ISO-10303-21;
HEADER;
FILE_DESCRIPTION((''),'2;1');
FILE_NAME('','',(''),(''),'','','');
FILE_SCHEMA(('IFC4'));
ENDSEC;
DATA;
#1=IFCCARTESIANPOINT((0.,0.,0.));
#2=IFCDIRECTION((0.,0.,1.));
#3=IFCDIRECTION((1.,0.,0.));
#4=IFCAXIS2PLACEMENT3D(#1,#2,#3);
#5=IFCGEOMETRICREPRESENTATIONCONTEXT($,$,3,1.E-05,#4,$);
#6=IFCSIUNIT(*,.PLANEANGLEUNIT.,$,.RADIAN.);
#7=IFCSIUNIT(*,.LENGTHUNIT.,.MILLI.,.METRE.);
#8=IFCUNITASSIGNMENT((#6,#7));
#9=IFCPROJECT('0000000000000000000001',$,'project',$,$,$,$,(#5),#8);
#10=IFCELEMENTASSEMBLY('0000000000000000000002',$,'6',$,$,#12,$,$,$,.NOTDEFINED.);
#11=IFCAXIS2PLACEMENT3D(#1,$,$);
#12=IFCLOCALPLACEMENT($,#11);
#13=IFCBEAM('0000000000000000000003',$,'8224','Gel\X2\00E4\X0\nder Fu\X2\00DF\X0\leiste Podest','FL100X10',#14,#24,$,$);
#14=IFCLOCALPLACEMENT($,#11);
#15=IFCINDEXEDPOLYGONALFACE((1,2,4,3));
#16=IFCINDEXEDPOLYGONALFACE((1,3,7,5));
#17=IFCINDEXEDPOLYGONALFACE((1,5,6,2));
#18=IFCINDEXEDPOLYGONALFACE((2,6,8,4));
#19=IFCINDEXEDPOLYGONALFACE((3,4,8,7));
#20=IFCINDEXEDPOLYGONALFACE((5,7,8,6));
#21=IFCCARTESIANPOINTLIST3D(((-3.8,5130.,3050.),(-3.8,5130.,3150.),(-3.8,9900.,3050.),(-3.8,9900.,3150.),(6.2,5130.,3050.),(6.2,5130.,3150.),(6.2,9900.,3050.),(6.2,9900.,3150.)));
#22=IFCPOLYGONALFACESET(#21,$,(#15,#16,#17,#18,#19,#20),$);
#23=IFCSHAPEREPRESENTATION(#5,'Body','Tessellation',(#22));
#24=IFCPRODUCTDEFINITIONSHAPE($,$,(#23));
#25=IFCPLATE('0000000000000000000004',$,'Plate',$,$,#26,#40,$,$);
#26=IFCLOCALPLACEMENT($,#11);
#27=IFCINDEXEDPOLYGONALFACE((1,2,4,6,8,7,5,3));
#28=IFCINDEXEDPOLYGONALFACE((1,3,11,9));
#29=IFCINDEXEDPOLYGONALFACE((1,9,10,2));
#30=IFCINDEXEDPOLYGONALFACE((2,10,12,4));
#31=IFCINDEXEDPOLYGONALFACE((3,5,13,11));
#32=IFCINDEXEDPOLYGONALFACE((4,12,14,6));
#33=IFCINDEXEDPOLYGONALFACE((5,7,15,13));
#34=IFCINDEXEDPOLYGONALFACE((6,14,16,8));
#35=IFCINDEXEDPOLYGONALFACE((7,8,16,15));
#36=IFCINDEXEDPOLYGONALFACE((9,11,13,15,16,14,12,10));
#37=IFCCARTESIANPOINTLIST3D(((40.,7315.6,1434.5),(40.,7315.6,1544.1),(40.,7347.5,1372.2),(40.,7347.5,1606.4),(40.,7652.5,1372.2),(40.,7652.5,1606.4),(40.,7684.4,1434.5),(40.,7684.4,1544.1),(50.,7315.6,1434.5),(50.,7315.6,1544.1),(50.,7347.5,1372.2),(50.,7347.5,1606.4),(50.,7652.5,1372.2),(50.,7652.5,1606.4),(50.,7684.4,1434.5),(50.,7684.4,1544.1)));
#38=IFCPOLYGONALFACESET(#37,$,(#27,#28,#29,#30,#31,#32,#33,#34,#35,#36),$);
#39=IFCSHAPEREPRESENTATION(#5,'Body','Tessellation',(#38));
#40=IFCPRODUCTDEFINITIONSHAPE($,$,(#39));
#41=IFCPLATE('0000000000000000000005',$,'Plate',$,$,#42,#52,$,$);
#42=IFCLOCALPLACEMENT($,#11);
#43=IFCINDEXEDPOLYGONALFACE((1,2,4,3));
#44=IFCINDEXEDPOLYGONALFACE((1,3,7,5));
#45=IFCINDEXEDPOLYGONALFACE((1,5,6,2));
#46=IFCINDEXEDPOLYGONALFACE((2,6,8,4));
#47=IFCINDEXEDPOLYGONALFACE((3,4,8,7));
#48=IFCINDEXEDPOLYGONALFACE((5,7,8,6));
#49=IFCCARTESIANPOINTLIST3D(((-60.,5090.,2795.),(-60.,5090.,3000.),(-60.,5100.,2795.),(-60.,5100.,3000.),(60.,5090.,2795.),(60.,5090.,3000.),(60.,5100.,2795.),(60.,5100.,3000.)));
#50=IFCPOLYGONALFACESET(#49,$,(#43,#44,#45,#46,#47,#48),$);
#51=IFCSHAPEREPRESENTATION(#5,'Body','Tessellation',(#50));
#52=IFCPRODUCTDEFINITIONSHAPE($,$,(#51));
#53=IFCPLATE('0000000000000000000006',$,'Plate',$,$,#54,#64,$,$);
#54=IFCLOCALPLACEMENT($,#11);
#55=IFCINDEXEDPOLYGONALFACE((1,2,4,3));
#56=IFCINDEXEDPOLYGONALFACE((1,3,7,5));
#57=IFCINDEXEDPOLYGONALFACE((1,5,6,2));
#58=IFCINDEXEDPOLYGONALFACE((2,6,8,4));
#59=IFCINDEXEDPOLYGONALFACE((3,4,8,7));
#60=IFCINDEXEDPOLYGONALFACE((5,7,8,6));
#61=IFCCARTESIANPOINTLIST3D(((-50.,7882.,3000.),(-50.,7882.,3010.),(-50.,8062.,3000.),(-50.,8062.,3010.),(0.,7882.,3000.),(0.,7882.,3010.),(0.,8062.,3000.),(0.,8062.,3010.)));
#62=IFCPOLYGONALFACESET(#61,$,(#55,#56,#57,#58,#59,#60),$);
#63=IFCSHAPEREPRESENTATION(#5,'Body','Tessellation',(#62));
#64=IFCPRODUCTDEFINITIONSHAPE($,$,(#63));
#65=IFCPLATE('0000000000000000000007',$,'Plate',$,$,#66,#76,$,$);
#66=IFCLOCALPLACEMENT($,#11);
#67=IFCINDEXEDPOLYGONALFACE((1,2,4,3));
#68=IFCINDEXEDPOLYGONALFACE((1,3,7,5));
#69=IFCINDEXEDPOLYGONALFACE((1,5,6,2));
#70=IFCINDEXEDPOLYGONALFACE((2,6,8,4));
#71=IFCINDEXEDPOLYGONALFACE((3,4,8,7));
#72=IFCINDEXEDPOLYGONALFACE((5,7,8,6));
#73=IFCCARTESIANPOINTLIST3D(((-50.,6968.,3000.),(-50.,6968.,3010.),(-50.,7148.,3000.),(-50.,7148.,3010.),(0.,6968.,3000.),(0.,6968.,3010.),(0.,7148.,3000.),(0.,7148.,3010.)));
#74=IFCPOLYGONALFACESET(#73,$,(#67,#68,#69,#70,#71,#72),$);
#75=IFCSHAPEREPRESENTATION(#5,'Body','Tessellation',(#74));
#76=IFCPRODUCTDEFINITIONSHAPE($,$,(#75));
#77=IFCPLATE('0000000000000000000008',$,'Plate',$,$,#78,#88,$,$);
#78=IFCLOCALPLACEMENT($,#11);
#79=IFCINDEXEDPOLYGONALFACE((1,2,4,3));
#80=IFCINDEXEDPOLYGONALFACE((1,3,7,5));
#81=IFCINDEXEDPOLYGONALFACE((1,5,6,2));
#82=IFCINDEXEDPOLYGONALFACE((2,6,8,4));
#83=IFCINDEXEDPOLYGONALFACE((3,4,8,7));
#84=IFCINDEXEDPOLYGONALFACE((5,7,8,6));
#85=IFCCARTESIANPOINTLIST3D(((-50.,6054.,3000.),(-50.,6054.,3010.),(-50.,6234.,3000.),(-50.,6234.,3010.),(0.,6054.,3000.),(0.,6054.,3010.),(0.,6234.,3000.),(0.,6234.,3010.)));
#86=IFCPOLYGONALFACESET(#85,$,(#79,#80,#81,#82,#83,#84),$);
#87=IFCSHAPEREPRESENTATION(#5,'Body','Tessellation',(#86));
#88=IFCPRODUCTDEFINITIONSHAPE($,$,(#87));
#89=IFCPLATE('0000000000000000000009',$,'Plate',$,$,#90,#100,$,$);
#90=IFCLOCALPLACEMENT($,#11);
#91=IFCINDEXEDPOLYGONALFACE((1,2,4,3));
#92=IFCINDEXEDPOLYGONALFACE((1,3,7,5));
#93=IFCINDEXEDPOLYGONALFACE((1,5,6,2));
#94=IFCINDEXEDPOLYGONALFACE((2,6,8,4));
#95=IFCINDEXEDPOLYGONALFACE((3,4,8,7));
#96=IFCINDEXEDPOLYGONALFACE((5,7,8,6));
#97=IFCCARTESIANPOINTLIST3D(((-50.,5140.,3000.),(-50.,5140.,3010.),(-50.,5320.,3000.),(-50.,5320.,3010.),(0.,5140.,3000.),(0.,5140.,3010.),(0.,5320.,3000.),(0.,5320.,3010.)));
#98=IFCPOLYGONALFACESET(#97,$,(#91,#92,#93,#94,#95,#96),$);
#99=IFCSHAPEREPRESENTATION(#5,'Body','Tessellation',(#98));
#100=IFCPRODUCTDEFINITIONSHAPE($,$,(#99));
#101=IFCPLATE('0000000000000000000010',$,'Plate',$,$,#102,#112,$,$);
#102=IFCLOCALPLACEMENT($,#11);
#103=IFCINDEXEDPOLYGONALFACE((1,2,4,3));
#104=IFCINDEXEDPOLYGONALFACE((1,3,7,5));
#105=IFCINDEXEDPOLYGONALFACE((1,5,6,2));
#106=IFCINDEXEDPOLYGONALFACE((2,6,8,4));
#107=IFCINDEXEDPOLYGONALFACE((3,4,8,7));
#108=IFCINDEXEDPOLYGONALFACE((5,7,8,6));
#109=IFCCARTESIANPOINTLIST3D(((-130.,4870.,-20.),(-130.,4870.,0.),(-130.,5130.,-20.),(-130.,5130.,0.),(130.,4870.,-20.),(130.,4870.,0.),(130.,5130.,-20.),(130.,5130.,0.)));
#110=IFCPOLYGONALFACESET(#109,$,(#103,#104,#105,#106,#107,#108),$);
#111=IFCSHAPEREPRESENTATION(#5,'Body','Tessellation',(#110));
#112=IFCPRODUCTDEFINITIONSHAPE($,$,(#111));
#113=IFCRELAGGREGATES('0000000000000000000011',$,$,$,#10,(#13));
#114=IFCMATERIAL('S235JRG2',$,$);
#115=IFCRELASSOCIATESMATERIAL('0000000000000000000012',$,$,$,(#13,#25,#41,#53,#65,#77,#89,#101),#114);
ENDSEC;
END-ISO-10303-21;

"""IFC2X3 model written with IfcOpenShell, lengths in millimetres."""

from ifc_helpers import new_model, si_unit, frame, origin_with_axes, place, context, project, polyline, outline, extrude, material, element, aggregate, save


model = new_model("IFC2X3")

# Units and contexts
context_of_model = context(None, 3, precision=1e-05, world=origin_with_axes())
ifc_project = project(units=[si_unit("PLANEANGLEUNIT", "RADIAN"), si_unit("LENGTHUNIT", "METRE", prefix="MILLI")], contexts=[context_of_model])

# Element assembly, beam
assembly_1_placement = place(None, frame((1.2, 5130.0, 6100.0), z_axis=(0.0, 0.0, 1.0), x_axis=(0.0, 1.0, 0.0)))
assembly_1 = element("IfcElementAssembly", 1, at=assembly_1_placement, Name="6", PredefinedType="NOTDEFINED")
ifc_material = material(Name="S235JRG2")
placement_1 = place(None, frame((1.2, 5130.0, 3100.0), z_axis=(0.0, 0.0, 1.0), x_axis=(0.0, 1.0, 0.0)))
beam_1_placement = place(placement_1, origin_with_axes())
beam_1 = element("IfcBeam", 2, at=beam_1_placement, material=ifc_material, Name="8224", Description="Geländer Fußleiste Podest", ObjectType="FL100X10", context=context_of_model, shape_type="SweptSolid", body=[
    extrude(outline(polyline([(5.0, -50.0), (5.0, 50.0), (-5.0, 50.0), (-5.0, -50.0), (5.0, -50.0), (5.0, -50.0)])), frame((0.0, 0.0, 0.0), z_axis=(1.0, 0.0, 0.0), x_axis=(0.0, 1.0, 0.0)), (0.0, 0.0, 1.0), 4770.0),
])
aggregate(assembly_1, [beam_1])

# Plates
placement_2 = place(None, frame((40.0, 7684.4, 1434.5), z_axis=(0.0, -1.0, 0.0), x_axis=(1.0, 0.0, 0.0)))
plate_1_placement = place(placement_2, origin_with_axes())
element("IfcPlate", 3, at=plate_1_placement, material=ifc_material, Name="Plate", context=context_of_model, shape_type="SweptSolid", body=[
    extrude(outline(polyline([(0.0, 0.0), (109.5, 0.0), (171.9, 31.8), (171.9, 336.9), (109.5, 368.7), (0.0, 368.7), (-62.4, 336.9), (-62.4, 31.8), (0.0, 0.0)])), frame((0.0, 0.0, 0.0), z_axis=(1.0, 0.0, 0.0), x_axis=(0.0, 1.0, 0.0)), (0.0, 0.0, 1.0), 10.0),
])
placement_3 = place(None, origin_with_axes())
plate_2_placement = place(placement_3, frame((60.0, 5100.0, 3000.0), z_axis=(0.0, 0.0, -1.0), x_axis=(0.0, -1.0, 0.0)))
element("IfcPlate", 4, at=plate_2_placement, material=ifc_material, Name="Plate", context=context_of_model, shape_type="SweptSolid", body=[
    extrude(outline(polyline([(0.0, 0.0), (120.0, 0.0), (120.0, 205.0), (0.0, 205.0), (0.0, 0.0)])), frame((0.0, 0.0, 0.0), z_axis=(1.0, 0.0, 0.0), x_axis=(0.0, 1.0, 0.0)), (0.0, 0.0, 1.0), 10.0),
])
placement_4 = place(None, origin_with_axes())
plate_3_placement = place(placement_4, frame((0.0, 8062.0, 3010.0), z_axis=(-1.0, 0.0, 0.0), x_axis=(0.0, 0.0, -1.0)))
element("IfcPlate", 5, at=plate_3_placement, material=ifc_material, Name="Plate", context=context_of_model, shape_type="SweptSolid", body=[
    extrude(outline(polyline([(0.0, 0.0), (180.0, 0.0), (180.0, 50.0), (0.0, 50.0), (0.0, 0.0)])), frame((0.0, 0.0, 0.0), z_axis=(1.0, 0.0, 0.0), x_axis=(0.0, 1.0, 0.0)), (0.0, 0.0, 1.0), 10.0),
])
placement_5 = place(None, origin_with_axes())
plate_4_placement = place(placement_5, frame((0.0, 7148.0, 3010.0), z_axis=(-1.0, 0.0, 0.0), x_axis=(0.0, 0.0, -1.0)))
element("IfcPlate", 6, at=plate_4_placement, material=ifc_material, Name="Plate", context=context_of_model, shape_type="SweptSolid", body=[
    extrude(outline(polyline([(0.0, 0.0), (180.0, 0.0), (180.0, 50.0), (0.0, 50.0), (0.0, 0.0)])), frame((0.0, 0.0, 0.0), z_axis=(1.0, 0.0, 0.0), x_axis=(0.0, 1.0, 0.0)), (0.0, 0.0, 1.0), 10.0),
])
placement_6 = place(None, origin_with_axes())
plate_5_placement = place(placement_6, frame((0.0, 6234.0, 3010.0), z_axis=(-1.0, 0.0, 0.0), x_axis=(0.0, 0.0, -1.0)))
element("IfcPlate", 7, at=plate_5_placement, material=ifc_material, Name="Plate", context=context_of_model, shape_type="SweptSolid", body=[
    extrude(outline(polyline([(0.0, 0.0), (180.0, 0.0), (180.0, 50.0), (0.0, 50.0), (0.0, 0.0)])), frame((0.0, 0.0, 0.0), z_axis=(1.0, 0.0, 0.0), x_axis=(0.0, 1.0, 0.0)), (0.0, 0.0, 1.0), 10.0),
])
placement_7 = place(None, origin_with_axes())
plate_6_placement = place(placement_7, frame((0.0, 5320.0, 3010.0), z_axis=(-1.0, 0.0, 0.0), x_axis=(0.0, 0.0, -1.0)))
element("IfcPlate", 8, at=plate_6_placement, material=ifc_material, Name="Plate", context=context_of_model, shape_type="SweptSolid", body=[
    extrude(outline(polyline([(0.0, 0.0), (180.0, 0.0), (180.0, 50.0), (0.0, 50.0), (0.0, 0.0)])), frame((0.0, 0.0, 0.0), z_axis=(1.0, 0.0, 0.0), x_axis=(0.0, 1.0, 0.0)), (0.0, 0.0, 1.0), 10.0),
])
placement_8 = place(None, origin_with_axes())
plate_7_placement = place(placement_8, frame((130.0, 5130.0, 0.0), z_axis=(-1.0, 0.0, 0.0), x_axis=(0.0, 0.0, -1.0)))
element("IfcPlate", 9, at=plate_7_placement, material=ifc_material, Name="Plate", context=context_of_model, shape_type="SweptSolid", body=[
    extrude(outline(polyline([(0.0, 0.0), (260.0, 0.0), (260.0, 260.0), (0.0, 260.0), (0.0, 0.0)])), frame((0.0, 0.0, 0.0), z_axis=(1.0, 0.0, 0.0), x_axis=(0.0, 1.0, 0.0)), (0.0, 0.0, 1.0), 20.0),
])

save(model, "model.ifc")
